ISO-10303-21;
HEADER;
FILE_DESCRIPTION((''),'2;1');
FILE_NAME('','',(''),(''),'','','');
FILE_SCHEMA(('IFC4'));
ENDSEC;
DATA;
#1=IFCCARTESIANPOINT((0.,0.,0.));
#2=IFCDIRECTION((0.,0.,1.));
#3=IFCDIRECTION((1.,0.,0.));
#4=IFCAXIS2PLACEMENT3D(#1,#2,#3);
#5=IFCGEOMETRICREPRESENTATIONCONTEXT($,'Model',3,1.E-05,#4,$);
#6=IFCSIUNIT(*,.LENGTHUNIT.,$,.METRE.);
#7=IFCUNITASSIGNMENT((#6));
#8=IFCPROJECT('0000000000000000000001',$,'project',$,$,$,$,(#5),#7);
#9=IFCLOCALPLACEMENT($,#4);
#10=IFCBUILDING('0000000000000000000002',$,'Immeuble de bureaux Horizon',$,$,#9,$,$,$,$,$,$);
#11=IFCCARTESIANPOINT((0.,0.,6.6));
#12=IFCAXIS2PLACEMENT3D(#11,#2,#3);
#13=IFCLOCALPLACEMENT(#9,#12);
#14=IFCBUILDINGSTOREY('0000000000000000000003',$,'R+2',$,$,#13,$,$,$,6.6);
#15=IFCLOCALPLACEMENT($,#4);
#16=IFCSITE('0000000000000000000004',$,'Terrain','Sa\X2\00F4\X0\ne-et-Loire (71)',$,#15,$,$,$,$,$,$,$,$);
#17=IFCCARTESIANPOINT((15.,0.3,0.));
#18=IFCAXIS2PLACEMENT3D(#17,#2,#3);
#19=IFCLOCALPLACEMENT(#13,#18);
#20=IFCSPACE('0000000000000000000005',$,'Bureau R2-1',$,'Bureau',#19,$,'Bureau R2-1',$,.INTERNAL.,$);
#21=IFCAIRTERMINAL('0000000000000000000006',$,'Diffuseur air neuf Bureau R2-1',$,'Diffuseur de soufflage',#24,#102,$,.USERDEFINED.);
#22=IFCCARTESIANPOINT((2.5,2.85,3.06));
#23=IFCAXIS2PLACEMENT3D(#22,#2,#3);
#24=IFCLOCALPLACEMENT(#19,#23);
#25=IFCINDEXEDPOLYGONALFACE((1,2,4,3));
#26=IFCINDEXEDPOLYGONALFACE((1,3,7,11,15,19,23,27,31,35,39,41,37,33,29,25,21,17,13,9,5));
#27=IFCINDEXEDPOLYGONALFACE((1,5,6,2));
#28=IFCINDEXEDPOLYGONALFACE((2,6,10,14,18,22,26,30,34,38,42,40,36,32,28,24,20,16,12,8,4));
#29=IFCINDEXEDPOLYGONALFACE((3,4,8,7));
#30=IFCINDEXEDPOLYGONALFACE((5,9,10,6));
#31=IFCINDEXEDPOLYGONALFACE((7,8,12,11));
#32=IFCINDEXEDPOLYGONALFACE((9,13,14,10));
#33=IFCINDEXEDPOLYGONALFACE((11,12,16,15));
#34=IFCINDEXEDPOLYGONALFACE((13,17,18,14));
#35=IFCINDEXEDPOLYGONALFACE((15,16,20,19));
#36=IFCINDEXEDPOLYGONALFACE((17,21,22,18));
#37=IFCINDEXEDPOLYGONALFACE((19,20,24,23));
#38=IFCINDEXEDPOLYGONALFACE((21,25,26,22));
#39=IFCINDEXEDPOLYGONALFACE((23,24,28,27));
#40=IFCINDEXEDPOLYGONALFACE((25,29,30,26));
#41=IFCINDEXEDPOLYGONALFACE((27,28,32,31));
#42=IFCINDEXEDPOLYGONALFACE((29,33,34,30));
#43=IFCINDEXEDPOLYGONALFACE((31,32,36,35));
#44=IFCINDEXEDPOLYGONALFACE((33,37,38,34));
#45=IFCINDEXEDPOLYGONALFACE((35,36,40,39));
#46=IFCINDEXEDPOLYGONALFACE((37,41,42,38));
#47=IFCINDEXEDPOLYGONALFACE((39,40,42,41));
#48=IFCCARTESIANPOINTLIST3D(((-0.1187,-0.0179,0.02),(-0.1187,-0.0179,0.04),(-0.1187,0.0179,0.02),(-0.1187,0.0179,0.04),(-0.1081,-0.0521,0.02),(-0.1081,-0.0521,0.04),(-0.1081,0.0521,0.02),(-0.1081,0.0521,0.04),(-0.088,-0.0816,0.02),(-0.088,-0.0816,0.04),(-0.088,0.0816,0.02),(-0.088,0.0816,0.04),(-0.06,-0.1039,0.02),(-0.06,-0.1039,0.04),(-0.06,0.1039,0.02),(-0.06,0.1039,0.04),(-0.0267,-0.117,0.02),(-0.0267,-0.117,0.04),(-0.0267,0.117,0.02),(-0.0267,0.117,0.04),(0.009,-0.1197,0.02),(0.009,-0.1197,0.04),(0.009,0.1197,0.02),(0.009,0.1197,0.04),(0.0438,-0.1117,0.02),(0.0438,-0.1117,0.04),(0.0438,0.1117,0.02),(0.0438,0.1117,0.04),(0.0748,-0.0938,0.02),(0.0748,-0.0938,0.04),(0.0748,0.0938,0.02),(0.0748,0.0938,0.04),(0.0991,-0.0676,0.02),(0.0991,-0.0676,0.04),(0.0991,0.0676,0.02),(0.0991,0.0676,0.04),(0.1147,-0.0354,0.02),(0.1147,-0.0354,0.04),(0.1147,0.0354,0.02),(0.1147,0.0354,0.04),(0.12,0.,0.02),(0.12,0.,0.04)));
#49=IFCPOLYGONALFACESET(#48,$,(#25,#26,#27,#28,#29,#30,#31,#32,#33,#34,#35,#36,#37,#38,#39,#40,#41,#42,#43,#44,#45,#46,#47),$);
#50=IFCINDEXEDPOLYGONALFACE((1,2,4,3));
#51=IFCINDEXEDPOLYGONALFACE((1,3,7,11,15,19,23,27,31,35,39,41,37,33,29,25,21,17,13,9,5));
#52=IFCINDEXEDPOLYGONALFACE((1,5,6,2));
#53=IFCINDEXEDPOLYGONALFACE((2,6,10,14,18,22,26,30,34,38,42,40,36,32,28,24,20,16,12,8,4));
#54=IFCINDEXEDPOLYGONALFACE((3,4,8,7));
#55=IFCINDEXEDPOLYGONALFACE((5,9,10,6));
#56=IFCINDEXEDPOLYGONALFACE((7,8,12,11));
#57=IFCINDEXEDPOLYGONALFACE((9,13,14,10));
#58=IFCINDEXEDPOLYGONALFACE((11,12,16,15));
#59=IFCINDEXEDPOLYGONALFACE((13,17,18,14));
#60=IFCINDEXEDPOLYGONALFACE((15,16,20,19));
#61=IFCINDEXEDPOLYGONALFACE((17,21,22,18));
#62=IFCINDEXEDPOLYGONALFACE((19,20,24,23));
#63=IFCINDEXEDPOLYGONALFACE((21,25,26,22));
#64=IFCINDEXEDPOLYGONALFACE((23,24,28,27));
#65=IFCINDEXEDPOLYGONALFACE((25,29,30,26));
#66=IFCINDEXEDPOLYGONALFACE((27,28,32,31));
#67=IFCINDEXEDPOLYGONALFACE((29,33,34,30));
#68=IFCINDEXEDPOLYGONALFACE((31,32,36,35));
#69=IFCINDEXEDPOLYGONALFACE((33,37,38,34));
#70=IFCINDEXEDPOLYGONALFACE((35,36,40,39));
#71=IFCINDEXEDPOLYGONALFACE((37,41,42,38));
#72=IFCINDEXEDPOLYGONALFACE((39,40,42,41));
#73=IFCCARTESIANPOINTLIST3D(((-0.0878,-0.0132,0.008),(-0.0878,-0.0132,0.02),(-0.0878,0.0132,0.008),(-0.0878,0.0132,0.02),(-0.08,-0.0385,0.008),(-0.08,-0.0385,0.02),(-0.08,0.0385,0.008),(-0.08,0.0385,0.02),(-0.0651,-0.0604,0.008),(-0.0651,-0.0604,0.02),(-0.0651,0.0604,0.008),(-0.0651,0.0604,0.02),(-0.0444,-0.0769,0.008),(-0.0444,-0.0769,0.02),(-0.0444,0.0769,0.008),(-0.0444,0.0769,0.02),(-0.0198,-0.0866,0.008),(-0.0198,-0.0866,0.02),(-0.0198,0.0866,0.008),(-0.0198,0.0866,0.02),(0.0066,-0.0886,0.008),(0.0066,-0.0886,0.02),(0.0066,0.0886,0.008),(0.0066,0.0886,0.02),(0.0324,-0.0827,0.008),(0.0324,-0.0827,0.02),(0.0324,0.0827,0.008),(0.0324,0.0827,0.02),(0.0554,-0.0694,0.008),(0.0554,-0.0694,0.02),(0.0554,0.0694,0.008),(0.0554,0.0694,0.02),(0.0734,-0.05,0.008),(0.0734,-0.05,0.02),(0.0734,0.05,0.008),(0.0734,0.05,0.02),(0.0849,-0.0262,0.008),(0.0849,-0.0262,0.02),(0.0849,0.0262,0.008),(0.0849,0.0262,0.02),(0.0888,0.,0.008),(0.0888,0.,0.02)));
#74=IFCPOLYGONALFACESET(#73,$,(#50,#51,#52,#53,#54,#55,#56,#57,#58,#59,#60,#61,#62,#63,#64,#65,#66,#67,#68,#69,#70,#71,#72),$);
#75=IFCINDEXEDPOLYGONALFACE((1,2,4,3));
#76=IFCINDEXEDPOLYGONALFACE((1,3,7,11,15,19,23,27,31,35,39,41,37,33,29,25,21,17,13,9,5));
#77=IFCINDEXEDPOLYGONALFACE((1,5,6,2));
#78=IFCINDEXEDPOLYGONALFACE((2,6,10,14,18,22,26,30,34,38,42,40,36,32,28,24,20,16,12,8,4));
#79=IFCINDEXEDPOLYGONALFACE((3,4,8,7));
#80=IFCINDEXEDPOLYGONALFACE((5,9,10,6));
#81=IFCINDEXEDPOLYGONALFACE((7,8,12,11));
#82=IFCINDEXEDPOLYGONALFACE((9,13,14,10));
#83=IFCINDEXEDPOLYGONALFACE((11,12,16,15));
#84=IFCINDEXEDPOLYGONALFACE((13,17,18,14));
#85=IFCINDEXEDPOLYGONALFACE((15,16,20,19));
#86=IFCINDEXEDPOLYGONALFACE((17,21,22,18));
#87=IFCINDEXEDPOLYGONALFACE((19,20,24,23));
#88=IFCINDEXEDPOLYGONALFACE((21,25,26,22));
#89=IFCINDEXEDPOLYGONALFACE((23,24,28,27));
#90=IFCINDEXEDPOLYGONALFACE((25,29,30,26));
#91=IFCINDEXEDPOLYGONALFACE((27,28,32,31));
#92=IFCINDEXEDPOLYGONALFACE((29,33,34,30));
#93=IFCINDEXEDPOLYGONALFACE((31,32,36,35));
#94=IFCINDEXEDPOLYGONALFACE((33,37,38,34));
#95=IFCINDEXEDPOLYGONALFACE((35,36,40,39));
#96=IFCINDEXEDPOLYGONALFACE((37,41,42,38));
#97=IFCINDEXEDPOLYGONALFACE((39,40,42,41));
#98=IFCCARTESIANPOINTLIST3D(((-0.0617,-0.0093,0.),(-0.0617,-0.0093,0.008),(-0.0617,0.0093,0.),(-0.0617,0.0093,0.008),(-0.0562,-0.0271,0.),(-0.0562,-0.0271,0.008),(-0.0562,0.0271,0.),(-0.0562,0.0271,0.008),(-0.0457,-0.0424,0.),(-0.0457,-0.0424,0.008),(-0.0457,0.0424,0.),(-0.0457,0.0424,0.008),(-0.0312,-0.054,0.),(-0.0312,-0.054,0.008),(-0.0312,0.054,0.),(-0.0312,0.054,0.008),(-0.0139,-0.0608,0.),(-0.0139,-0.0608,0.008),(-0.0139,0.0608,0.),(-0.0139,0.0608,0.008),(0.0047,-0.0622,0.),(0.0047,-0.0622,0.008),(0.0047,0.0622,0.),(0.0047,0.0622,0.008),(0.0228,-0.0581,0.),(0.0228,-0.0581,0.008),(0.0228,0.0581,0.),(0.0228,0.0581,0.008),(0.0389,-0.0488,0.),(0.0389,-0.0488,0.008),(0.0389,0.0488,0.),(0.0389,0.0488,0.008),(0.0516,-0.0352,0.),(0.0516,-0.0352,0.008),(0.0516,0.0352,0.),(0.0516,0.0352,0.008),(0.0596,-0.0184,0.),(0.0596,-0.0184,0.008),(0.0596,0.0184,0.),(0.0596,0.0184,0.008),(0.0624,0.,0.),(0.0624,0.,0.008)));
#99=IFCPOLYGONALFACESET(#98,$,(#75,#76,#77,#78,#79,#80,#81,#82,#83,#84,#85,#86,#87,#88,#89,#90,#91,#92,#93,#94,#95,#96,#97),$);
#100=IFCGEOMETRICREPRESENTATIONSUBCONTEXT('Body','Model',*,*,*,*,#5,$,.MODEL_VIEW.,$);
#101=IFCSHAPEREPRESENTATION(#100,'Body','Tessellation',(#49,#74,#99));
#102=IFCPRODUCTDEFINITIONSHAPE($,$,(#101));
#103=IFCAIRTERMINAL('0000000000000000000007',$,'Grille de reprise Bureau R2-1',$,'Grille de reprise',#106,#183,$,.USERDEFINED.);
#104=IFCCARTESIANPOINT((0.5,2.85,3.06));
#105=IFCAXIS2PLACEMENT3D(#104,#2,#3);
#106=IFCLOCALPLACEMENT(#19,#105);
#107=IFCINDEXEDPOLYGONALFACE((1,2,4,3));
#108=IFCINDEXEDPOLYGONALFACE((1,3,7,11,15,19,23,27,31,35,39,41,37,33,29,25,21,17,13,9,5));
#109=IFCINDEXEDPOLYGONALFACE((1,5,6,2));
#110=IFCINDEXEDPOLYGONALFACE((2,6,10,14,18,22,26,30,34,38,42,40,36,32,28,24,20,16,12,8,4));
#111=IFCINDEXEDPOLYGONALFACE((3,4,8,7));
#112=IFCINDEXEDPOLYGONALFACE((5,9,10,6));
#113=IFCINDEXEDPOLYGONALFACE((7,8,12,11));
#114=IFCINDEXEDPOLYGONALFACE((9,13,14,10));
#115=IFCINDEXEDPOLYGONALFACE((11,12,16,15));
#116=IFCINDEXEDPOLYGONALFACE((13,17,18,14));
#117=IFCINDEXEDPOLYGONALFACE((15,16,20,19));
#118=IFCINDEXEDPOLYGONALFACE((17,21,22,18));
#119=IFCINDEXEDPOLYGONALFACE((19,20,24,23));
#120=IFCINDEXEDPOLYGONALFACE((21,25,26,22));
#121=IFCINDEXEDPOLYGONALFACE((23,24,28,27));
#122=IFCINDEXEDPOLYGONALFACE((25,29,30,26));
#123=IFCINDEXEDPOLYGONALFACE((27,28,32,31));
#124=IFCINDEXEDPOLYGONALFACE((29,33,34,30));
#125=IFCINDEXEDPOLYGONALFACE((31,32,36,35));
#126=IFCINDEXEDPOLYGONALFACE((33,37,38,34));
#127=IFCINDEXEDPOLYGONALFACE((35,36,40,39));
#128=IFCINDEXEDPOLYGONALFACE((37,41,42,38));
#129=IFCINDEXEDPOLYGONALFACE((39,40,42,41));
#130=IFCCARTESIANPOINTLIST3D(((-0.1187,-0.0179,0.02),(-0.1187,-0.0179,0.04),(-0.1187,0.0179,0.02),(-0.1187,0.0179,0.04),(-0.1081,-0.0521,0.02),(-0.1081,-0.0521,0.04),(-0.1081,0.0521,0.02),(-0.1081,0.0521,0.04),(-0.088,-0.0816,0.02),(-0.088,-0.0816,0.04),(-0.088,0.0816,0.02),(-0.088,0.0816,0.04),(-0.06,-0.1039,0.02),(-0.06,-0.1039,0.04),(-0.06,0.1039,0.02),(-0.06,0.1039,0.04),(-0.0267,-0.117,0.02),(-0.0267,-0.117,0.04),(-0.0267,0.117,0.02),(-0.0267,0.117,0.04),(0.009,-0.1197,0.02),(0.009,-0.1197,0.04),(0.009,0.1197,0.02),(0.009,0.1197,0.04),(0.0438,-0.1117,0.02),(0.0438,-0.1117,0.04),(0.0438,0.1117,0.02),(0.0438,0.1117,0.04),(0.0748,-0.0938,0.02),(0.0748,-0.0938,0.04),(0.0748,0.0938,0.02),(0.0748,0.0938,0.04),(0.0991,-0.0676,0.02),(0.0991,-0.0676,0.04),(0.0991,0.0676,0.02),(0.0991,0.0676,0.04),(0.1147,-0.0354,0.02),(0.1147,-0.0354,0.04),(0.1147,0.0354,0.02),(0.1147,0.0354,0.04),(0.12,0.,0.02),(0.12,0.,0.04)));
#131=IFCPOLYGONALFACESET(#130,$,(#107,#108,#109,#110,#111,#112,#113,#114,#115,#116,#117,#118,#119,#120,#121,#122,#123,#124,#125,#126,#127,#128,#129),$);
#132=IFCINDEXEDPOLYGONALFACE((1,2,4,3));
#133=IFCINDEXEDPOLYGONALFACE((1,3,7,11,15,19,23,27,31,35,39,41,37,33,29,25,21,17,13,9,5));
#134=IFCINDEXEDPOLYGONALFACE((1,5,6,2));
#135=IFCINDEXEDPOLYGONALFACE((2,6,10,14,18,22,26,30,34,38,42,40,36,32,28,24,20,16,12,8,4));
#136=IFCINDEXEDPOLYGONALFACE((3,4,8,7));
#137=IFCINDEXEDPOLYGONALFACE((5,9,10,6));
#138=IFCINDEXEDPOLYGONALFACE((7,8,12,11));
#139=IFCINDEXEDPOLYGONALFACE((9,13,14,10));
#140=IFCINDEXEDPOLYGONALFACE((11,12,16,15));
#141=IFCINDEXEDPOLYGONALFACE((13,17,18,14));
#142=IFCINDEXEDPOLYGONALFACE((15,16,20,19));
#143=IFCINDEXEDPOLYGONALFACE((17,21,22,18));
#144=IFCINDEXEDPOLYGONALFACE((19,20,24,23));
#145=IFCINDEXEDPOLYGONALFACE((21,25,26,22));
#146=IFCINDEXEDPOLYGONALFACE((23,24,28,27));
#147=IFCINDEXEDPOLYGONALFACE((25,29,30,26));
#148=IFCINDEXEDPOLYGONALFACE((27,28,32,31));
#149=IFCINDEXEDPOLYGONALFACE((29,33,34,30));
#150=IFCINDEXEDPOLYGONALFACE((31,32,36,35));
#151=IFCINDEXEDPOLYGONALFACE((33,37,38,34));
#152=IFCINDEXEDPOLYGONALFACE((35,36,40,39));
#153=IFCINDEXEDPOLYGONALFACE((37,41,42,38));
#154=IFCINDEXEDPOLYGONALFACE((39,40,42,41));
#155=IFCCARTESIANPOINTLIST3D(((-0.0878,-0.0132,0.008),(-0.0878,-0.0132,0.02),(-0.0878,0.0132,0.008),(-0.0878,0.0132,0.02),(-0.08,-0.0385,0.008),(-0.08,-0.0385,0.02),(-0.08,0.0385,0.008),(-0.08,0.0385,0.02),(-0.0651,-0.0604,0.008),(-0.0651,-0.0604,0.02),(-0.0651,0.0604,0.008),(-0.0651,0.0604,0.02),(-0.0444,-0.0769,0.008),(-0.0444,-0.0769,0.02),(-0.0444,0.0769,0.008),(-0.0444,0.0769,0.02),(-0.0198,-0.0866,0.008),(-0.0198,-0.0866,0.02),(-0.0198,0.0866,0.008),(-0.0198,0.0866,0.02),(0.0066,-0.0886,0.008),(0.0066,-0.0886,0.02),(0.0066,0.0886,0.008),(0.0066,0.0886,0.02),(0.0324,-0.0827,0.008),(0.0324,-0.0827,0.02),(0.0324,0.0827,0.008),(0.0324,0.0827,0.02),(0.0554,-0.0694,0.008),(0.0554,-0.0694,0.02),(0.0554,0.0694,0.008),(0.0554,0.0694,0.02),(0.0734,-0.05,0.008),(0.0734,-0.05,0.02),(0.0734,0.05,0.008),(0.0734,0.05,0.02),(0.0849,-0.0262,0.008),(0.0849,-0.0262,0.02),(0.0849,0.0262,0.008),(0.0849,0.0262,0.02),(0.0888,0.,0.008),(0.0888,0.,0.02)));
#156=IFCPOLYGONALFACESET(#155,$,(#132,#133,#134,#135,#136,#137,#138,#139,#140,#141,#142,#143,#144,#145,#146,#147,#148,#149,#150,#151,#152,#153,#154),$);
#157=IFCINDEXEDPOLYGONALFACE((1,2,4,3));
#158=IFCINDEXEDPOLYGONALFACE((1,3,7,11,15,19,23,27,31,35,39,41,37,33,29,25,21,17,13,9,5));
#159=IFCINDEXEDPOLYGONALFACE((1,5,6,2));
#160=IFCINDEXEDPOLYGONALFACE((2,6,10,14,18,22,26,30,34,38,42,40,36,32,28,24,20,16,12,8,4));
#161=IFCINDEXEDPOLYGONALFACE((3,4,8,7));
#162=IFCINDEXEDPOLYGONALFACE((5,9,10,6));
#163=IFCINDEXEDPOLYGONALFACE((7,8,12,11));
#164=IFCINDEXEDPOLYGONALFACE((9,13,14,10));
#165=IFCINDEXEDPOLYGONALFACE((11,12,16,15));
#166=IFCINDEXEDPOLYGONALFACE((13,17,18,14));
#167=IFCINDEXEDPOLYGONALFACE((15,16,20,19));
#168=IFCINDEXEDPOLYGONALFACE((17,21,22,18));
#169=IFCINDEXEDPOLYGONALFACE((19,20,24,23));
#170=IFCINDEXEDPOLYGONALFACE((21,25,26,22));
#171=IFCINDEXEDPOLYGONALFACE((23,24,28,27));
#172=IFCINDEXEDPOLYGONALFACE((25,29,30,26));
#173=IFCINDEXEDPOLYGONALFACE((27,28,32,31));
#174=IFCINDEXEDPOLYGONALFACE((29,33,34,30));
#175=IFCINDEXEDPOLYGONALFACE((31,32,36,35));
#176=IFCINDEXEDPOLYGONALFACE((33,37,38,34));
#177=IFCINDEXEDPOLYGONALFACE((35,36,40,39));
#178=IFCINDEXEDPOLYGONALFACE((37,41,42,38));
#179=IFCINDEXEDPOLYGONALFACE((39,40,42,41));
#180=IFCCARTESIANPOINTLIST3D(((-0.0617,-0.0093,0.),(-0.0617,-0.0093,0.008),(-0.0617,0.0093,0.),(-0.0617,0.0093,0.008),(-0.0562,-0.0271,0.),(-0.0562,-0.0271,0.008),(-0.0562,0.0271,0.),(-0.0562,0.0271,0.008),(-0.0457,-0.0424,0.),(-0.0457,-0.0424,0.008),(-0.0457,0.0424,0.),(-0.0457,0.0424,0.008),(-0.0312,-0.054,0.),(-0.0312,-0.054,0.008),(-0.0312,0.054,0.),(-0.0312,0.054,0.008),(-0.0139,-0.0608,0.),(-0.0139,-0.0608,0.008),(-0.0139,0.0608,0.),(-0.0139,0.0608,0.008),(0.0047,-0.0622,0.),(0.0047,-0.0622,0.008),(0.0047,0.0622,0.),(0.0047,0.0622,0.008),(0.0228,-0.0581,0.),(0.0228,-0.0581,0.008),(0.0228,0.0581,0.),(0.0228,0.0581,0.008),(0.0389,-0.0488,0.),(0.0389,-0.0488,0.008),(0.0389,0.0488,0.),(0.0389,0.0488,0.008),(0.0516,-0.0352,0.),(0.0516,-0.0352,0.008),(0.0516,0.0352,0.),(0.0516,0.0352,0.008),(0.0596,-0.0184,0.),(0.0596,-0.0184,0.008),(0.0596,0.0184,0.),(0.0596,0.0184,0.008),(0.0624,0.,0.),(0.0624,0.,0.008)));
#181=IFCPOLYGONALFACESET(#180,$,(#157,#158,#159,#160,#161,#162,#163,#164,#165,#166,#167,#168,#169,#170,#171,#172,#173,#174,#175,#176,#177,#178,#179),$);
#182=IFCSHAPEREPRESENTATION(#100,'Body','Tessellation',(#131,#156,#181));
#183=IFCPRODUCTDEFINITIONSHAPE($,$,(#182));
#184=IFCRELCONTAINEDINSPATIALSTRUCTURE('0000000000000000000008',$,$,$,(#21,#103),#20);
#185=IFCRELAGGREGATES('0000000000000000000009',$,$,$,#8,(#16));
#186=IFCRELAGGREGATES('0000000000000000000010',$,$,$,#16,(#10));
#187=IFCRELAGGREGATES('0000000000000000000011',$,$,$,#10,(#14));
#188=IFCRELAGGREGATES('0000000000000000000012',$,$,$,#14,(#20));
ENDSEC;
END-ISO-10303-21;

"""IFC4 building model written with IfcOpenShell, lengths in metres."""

from ifc_helpers import new_model, si_unit, frame, origin_with_axes, place, context, subcontext, project, spatial, circle, extrude, element, save


model = new_model("IFC4")

# Units and contexts
model_context = context("Model", 3, precision=1e-05, world=origin_with_axes())
body_context = subcontext(model_context, "Body", "Model", "MODEL_VIEW")
ifc_project = project(units=[si_unit("LENGTHUNIT", "METRE")], contexts=[model_context])

# Site, building, storey
site_placement = place(None, origin_with_axes())
site = spatial("IfcSite", under=ifc_project, at=site_placement, Name="Terrain", Description="Saône-et-Loire (71)")
building_placement = place(None, origin_with_axes())
building = spatial("IfcBuilding", under=site, at=building_placement, Name="Immeuble de bureaux Horizon")
storey_placement = place(building_placement, frame((0.0, 0.0, 6.6), z_axis=(0.0, 0.0, 1.0), x_axis=(1.0, 0.0, 0.0)))
storey = spatial("IfcBuildingStorey", under=building, at=storey_placement, Name="R+2", Elevation=6.6)

# Shared definitions
space_1_placement = place(storey_placement, frame((15.0, 0.3, 0.0), z_axis=(0.0, 0.0, 1.0), x_axis=(1.0, 0.0, 0.0)))
space_1 = spatial("IfcSpace", under=storey, at=space_1_placement, Name="Bureau R2-1", ObjectType="Bureau", LongName="Bureau R2-1", PredefinedType="INTERNAL")

# Air terminal
air_terminal_1_placement = place(space_1_placement, frame((2.5, 2.85, 3.06), z_axis=(0.0, 0.0, 1.0), x_axis=(1.0, 0.0, 0.0)))
element("IfcAirTerminal", 1, at=air_terminal_1_placement, inside=space_1, Name="Diffuseur air neuf Bureau R2-1", ObjectType="Diffuseur de soufflage", PredefinedType="USERDEFINED", context=body_context, shape_type="SweptSolid", body=[
    extrude(circle(Radius=0.12), frame((0.0, 0.0, 0.02), z_axis=(0.0, 0.0, 1.0), x_axis=(1.0, 0.0, 0.0)), (0.0, 0.0, 1.0), 0.02),
    extrude(circle(Radius=0.0888), frame((0.0, 0.0, 0.008), z_axis=(0.0, 0.0, 1.0), x_axis=(1.0, 0.0, 0.0)), (0.0, 0.0, 1.0), 0.012),
    extrude(circle(Radius=0.0624), origin_with_axes(), (0.0, 0.0, 1.0), 0.008),
])

# Air terminal
air_terminal_2_placement = place(space_1_placement, frame((0.5, 2.85, 3.06), z_axis=(0.0, 0.0, 1.0), x_axis=(1.0, 0.0, 0.0)))
element("IfcAirTerminal", 2, at=air_terminal_2_placement, inside=space_1, Name="Grille de reprise Bureau R2-1", ObjectType="Grille de reprise", PredefinedType="USERDEFINED", context=body_context, shape_type="SweptSolid", body=[
    extrude(circle(Radius=0.12), frame((0.0, 0.0, 0.02), z_axis=(0.0, 0.0, 1.0), x_axis=(1.0, 0.0, 0.0)), (0.0, 0.0, 1.0), 0.02),
    extrude(circle(Radius=0.0888), frame((0.0, 0.0, 0.008), z_axis=(0.0, 0.0, 1.0), x_axis=(1.0, 0.0, 0.0)), (0.0, 0.0, 1.0), 0.012),
    extrude(circle(Radius=0.0624), origin_with_axes(), (0.0, 0.0, 1.0), 0.008),
])

save(model, "model.ifc")
